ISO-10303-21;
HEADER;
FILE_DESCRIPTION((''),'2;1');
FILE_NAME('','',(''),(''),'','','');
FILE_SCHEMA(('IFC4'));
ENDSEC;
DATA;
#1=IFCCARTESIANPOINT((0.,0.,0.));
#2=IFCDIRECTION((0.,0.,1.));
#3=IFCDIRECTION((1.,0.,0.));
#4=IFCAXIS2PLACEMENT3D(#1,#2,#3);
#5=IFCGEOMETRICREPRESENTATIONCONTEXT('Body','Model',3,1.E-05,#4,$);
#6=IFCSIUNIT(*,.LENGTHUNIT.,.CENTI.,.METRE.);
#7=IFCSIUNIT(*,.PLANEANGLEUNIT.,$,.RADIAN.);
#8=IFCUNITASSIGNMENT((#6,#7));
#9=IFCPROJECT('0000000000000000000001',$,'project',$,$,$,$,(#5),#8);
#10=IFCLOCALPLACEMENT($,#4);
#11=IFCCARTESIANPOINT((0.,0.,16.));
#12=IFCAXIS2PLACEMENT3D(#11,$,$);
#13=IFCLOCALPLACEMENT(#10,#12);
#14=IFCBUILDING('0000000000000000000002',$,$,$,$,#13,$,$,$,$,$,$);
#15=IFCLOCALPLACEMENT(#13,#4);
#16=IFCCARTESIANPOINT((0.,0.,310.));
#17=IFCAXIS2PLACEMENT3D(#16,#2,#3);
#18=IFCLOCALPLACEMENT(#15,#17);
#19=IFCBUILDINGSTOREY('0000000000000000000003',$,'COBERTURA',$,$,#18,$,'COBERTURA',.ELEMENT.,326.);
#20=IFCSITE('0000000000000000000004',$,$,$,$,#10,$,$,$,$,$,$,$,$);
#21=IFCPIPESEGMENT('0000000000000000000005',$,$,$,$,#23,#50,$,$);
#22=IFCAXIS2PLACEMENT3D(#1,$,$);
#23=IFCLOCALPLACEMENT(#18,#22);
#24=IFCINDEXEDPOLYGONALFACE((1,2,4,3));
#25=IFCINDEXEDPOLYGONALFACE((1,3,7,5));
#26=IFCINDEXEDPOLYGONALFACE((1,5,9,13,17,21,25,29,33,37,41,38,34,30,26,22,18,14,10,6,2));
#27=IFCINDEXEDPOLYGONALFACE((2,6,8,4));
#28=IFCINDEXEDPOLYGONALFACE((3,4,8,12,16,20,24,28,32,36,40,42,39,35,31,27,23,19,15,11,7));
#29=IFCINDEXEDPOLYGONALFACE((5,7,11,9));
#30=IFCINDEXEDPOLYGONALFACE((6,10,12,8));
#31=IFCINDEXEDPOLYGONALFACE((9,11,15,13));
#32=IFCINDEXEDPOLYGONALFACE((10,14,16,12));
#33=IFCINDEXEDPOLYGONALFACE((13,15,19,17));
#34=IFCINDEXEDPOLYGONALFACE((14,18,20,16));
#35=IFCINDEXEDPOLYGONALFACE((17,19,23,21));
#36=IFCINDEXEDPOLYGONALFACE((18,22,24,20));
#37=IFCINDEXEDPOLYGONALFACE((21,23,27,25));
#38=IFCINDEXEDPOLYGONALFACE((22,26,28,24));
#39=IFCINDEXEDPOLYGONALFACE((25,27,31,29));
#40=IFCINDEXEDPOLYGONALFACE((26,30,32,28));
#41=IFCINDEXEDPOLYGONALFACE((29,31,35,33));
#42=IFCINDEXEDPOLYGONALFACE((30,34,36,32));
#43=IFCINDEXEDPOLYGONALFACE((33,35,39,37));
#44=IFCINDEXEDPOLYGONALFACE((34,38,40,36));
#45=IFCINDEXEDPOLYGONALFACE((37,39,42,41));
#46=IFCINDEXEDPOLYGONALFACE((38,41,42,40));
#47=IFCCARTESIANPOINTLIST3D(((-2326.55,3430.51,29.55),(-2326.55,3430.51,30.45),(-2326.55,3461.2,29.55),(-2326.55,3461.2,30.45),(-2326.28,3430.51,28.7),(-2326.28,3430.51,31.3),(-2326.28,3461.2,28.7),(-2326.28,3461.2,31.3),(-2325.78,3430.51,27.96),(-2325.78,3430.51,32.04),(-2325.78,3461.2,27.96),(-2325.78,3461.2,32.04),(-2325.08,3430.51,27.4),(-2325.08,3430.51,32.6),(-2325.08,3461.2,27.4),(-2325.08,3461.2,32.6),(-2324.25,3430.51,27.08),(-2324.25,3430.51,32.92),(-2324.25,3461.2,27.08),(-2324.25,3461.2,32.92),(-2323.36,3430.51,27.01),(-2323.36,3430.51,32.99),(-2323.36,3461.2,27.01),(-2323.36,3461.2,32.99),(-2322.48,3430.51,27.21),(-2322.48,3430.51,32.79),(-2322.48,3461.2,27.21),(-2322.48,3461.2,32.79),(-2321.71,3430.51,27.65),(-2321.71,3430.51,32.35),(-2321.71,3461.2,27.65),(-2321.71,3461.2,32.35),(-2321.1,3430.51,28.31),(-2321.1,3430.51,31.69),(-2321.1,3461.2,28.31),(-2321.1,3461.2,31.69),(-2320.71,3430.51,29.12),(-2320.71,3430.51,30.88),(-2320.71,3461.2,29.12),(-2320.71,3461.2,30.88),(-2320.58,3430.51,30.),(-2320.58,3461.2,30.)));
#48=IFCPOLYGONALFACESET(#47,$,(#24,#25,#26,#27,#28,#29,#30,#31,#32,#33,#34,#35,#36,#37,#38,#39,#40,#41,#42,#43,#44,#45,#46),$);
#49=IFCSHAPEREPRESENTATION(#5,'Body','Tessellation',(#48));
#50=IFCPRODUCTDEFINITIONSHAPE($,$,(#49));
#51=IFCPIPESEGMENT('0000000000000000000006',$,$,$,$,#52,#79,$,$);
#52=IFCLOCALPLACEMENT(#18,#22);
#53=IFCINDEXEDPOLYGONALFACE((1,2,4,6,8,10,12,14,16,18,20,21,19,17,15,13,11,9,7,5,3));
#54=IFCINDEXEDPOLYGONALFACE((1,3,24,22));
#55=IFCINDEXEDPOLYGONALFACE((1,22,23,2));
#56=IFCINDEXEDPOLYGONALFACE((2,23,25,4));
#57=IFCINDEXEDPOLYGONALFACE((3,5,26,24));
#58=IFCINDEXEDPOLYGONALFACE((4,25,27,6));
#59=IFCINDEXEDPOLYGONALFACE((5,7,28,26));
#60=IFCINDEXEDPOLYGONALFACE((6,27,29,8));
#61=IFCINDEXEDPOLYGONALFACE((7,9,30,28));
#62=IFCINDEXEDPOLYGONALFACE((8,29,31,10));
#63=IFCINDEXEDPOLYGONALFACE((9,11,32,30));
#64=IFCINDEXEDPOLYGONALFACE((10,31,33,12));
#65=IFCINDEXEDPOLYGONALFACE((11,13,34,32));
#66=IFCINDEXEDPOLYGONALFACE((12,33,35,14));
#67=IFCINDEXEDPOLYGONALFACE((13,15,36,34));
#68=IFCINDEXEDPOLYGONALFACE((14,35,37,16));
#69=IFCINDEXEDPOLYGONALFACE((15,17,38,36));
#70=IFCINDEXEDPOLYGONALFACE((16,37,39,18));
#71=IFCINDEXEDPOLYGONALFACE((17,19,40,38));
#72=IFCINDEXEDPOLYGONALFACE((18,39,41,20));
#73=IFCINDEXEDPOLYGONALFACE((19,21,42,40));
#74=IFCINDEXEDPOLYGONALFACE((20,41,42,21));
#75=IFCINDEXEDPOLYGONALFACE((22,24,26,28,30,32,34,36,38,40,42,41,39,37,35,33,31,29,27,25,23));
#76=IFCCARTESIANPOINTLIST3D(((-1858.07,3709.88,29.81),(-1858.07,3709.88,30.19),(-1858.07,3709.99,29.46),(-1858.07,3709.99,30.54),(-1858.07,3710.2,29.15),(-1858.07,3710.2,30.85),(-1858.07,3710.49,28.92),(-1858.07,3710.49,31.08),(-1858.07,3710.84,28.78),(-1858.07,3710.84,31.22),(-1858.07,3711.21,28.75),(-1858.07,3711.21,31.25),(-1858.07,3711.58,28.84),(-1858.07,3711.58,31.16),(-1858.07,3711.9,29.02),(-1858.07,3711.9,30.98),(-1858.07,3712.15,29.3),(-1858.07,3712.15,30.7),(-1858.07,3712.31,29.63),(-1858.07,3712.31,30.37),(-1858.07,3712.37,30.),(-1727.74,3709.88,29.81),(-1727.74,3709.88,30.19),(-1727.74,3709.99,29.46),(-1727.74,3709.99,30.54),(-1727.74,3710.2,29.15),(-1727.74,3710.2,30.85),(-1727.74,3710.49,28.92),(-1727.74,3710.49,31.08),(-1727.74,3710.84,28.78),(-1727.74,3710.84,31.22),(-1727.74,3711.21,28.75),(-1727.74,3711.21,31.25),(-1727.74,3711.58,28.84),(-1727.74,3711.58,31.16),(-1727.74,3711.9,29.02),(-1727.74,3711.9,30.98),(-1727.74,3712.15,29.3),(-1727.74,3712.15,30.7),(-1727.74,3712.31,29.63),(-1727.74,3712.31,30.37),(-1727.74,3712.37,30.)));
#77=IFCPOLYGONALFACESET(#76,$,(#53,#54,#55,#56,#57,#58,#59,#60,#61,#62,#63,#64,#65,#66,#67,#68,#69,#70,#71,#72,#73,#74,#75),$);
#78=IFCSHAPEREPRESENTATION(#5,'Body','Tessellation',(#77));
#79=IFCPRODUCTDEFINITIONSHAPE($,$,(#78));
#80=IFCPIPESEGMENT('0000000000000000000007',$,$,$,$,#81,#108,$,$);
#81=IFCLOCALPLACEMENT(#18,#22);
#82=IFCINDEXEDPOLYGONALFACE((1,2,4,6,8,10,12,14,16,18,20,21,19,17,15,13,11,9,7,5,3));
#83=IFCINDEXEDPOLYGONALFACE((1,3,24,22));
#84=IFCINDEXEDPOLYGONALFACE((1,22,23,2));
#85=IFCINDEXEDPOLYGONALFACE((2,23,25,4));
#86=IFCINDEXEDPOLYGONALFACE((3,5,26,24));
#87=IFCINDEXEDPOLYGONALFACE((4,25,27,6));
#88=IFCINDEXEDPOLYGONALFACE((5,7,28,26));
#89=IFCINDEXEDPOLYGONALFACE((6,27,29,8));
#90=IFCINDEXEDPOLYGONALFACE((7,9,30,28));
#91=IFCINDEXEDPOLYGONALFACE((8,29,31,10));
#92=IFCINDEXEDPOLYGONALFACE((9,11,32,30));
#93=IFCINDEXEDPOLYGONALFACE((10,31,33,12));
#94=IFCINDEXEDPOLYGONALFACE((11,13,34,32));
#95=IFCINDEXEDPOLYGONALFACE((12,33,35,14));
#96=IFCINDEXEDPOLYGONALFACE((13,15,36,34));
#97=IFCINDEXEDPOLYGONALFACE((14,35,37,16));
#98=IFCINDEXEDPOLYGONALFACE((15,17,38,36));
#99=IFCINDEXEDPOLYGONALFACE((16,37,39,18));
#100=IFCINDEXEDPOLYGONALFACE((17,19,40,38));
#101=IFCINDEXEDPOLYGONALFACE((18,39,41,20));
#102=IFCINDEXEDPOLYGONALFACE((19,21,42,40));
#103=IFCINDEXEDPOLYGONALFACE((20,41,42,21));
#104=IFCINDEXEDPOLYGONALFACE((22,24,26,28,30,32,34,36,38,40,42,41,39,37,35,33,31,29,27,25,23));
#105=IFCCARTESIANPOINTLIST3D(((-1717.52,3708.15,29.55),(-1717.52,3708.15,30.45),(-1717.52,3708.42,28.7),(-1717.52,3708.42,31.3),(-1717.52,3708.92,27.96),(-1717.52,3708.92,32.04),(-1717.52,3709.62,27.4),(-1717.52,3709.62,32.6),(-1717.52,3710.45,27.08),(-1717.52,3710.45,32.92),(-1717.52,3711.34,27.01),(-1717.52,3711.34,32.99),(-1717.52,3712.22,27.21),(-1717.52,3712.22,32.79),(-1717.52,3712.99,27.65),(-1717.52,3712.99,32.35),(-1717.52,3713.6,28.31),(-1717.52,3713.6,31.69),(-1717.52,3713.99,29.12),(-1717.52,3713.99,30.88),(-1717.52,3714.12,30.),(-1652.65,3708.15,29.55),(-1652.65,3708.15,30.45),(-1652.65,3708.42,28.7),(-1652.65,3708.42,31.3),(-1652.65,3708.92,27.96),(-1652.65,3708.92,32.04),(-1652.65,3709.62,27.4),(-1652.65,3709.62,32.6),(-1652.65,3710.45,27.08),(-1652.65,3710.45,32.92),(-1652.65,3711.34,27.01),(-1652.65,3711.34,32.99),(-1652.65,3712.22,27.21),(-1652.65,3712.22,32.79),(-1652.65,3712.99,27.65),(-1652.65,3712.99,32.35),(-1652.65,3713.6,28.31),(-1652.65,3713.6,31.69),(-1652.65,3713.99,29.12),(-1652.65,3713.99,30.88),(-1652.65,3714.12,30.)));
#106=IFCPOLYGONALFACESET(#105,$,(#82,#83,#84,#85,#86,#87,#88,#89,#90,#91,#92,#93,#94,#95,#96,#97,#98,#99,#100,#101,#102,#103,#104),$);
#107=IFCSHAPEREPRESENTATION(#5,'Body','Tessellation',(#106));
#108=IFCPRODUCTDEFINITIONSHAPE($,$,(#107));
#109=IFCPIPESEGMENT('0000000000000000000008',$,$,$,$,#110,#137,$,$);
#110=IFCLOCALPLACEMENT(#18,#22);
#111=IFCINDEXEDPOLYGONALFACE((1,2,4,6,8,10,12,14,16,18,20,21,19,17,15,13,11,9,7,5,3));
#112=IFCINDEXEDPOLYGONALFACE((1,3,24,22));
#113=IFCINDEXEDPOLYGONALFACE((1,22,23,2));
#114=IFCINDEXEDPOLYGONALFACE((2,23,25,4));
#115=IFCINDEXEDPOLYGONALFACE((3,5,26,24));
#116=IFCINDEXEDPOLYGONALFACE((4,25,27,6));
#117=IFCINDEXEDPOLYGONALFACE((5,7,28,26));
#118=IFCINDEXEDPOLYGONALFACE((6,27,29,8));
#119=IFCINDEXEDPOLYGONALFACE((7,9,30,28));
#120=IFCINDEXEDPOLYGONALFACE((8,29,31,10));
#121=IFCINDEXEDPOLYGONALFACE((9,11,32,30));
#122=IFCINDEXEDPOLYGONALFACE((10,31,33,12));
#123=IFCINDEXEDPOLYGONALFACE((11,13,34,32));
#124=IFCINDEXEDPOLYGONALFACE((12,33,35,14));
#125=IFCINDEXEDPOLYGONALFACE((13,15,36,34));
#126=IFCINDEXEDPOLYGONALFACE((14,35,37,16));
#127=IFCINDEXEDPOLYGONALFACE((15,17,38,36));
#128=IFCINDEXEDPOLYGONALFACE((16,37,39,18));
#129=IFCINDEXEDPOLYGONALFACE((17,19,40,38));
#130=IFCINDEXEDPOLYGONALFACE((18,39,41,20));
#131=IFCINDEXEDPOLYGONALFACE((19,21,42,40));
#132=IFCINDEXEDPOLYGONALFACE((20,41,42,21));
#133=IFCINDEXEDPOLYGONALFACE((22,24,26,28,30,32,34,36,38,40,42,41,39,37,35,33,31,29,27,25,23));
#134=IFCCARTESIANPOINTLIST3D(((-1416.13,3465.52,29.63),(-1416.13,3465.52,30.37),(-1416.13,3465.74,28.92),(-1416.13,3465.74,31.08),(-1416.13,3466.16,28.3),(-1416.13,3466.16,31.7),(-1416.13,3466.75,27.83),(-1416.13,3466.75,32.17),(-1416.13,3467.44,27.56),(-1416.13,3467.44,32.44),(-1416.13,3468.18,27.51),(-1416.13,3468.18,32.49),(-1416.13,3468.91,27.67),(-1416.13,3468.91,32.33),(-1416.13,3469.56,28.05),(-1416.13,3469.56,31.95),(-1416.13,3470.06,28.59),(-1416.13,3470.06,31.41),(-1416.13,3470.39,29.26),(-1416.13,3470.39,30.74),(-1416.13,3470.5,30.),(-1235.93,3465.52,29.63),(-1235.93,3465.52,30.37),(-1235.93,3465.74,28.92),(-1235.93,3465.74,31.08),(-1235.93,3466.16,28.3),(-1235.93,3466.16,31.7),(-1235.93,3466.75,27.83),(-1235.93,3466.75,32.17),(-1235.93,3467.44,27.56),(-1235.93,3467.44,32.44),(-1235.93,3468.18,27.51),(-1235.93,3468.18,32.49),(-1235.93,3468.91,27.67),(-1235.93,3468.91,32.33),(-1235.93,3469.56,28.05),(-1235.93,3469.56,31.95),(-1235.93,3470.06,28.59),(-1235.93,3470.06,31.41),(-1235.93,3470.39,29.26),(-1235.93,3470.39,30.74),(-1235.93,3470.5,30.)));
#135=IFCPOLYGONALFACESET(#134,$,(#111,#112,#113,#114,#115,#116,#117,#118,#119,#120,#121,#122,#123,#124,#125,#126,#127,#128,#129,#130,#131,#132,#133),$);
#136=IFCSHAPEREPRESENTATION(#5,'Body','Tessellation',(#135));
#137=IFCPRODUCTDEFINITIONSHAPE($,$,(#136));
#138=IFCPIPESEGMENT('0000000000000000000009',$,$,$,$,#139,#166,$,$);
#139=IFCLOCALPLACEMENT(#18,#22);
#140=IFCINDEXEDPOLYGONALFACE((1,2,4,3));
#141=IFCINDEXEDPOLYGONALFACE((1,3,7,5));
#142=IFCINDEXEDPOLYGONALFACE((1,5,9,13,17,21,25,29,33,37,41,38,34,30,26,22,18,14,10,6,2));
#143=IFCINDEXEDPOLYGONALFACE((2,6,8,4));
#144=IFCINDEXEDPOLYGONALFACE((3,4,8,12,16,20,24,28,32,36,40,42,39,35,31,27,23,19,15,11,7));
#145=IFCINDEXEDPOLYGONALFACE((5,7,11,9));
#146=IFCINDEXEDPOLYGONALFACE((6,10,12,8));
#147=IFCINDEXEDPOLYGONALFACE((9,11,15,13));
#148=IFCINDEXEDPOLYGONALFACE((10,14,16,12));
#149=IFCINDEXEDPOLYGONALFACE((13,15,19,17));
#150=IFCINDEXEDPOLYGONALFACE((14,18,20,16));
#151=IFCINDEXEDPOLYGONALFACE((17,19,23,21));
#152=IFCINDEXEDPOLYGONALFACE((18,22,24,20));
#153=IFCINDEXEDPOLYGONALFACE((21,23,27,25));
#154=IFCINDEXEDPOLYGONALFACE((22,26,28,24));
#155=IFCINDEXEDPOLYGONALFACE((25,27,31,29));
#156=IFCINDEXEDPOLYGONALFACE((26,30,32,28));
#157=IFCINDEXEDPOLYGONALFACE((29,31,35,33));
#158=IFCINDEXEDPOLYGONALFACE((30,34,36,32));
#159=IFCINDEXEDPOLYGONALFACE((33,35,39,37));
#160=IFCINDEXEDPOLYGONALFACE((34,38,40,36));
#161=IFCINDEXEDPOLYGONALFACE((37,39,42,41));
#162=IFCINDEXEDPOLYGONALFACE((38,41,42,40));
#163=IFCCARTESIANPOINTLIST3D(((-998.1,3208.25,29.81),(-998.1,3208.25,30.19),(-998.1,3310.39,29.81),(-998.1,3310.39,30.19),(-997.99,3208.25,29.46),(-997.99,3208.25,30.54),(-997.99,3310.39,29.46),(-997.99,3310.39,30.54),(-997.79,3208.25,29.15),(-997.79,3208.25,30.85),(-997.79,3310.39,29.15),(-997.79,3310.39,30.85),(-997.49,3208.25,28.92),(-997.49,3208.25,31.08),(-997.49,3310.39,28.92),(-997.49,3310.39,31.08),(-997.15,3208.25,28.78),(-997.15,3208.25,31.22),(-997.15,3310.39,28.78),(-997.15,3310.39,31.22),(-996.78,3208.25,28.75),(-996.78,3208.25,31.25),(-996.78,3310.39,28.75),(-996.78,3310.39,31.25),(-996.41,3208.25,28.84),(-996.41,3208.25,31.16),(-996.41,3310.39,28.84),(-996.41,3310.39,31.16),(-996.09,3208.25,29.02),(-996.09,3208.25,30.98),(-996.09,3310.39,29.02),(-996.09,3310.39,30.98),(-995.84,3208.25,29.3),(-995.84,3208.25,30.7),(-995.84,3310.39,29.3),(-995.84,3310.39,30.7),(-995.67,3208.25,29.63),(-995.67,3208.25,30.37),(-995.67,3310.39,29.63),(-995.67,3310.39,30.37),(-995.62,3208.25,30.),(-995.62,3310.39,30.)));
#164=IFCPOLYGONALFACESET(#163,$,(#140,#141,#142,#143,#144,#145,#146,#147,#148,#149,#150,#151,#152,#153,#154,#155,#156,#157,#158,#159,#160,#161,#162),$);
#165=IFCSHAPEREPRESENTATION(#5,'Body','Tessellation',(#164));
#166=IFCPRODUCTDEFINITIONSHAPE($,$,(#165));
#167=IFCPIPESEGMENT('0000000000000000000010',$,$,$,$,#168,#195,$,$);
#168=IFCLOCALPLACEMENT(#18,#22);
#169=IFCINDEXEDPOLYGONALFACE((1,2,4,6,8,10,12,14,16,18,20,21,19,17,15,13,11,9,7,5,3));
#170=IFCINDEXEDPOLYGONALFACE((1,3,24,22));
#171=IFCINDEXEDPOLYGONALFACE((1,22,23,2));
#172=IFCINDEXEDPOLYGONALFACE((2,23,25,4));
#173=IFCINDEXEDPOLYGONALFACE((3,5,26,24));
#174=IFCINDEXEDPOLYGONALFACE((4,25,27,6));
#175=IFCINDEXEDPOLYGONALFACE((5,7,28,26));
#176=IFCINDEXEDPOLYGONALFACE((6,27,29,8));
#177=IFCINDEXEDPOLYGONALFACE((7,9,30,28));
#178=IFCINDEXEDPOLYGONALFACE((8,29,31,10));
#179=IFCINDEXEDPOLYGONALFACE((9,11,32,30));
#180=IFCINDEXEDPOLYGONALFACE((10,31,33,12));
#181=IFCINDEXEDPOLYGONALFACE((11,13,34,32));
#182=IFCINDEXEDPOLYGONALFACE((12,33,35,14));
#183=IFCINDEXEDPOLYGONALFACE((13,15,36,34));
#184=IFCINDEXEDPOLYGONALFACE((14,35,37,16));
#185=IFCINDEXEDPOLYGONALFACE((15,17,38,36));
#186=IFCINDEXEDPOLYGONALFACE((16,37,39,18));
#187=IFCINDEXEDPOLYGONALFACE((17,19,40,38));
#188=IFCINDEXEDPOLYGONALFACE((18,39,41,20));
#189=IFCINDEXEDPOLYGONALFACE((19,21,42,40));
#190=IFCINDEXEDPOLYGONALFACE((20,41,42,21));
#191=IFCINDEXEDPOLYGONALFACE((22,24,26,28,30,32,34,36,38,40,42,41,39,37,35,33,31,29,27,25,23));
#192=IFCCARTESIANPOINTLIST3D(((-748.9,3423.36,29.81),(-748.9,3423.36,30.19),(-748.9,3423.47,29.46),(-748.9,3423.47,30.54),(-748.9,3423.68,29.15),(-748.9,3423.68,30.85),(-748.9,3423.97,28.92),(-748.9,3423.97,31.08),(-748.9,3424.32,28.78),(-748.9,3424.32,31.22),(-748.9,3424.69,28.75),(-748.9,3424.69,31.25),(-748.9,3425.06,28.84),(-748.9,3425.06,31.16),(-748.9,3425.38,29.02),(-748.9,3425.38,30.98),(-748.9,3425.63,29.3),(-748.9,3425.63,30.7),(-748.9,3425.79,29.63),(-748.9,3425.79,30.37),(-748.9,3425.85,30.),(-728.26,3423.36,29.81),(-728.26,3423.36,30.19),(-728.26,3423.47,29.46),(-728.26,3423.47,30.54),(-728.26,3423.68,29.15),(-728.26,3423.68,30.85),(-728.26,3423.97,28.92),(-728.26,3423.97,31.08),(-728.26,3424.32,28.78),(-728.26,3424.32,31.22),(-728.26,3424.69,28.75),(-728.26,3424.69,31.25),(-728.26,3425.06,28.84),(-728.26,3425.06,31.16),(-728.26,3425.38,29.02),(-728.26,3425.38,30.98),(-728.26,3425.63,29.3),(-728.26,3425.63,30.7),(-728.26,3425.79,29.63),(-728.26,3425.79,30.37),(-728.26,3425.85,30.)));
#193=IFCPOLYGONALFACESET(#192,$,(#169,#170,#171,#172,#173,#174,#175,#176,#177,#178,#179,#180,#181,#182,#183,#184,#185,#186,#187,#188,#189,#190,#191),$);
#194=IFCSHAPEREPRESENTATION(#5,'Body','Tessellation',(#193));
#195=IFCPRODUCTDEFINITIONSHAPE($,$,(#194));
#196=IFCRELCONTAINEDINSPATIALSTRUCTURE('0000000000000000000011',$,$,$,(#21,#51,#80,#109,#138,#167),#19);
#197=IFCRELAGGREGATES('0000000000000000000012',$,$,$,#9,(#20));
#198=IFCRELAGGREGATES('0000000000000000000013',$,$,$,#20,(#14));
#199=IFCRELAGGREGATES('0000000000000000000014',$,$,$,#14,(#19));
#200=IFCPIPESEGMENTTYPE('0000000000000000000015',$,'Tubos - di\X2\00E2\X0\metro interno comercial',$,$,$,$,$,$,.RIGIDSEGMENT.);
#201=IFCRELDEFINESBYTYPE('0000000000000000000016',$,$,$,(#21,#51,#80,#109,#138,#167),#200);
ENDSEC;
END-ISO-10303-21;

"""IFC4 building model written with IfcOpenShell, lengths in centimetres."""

from ifc_helpers import new_model, si_unit, frame, origin_with_axes, origin_2d_with_axis, place, context, project, spatial, circle, extrude, type_object, element, save


model = new_model("IFC4")

# Units and contexts
model_context = context("Model", 3, precision=1e-05, world=origin_with_axes(), identifier="Body")
ifc_project = project(units=[si_unit("LENGTHUNIT", "METRE", prefix="CENTI"), si_unit("PLANEANGLEUNIT", "RADIAN")], contexts=[model_context])

# Site, building, storey
site_placement = place(None, origin_with_axes())
site = spatial("IfcSite", under=ifc_project, at=site_placement)
building_placement = place(site_placement, frame((0.0, 0.0, 16.0)))
building = spatial("IfcBuilding", under=site, at=building_placement)
placement = place(building_placement, origin_with_axes())
storey_placement = place(placement, frame((0.0, 0.0, 310.0), z_axis=(0.0, 0.0, 1.0), x_axis=(1.0, 0.0, 0.0)))
storey = spatial("IfcBuildingStorey", under=building, at=storey_placement, Name="COBERTURA", LongName="COBERTURA", CompositionType="ELEMENT", Elevation=326.0)

# Pipe segments
pipe_segment_type = type_object("IfcPipeSegmentType", Name="Tubos - diâmetro interno comercial", PredefinedType="RIGIDSEGMENT")
pipe_segment_1_placement = place(storey_placement, frame((-2323.58, 3445.85, 33.0), z_axis=(0.0, 0.0, 1.0), x_axis=(1.0, 0.0, 0.0)))
element("IfcPipeSegment", 1, at=pipe_segment_1_placement, inside=storey, type_object=pipe_segment_type, context=model_context, shape_type="SolidModel", body=[
    extrude(circle(Radius=3.0, at=origin_2d_with_axis()), frame((0.0, -15.34, -3.0), z_axis=(0.0, 1.0, 0.0), x_axis=(1.0, 0.0, 0.0)), (0.0, 0.0, 1.0), 30.69),
])
pipe_segment_2_placement = place(storey_placement, frame((-1792.91, 3711.12, 31.25), z_axis=(0.0, 0.0, 1.0), x_axis=(1.0, 0.0, 0.0)))
element("IfcPipeSegment", 2, at=pipe_segment_2_placement, inside=storey, type_object=pipe_segment_type, context=model_context, shape_type="SolidModel", body=[
    extrude(circle(Radius=1.25, at=origin_2d_with_axis()), frame((65.16, 0.0, -1.25), z_axis=(-1.0, 0.0, 0.0), x_axis=(0.0, 1.0, 0.0)), (0.0, 0.0, 1.0), 130.33),
])
pipe_segment_3_placement = place(storey_placement, frame((-1685.08, 3711.12, 33.0), z_axis=(0.0, 0.0, 1.0), x_axis=(1.0, 0.0, 0.0)))
element("IfcPipeSegment", 3, at=pipe_segment_3_placement, inside=storey, type_object=pipe_segment_type, context=model_context, shape_type="SolidModel", body=[
    extrude(circle(Radius=3.0, at=origin_2d_with_axis()), frame((32.44, 0.0, -3.0), z_axis=(-1.0, 0.0, 0.0), x_axis=(0.0, 1.0, 0.0)), (0.0, 0.0, 1.0), 64.87),
])
pipe_segment_4_placement = place(storey_placement, frame((-1326.03, 3468.0, 32.5), z_axis=(0.0, 0.0, 1.0), x_axis=(1.0, 0.0, 0.0)))
element("IfcPipeSegment", 4, at=pipe_segment_4_placement, inside=storey, type_object=pipe_segment_type, context=model_context, shape_type="SolidModel", body=[
    extrude(circle(Radius=2.5, at=origin_2d_with_axis()), frame((-90.1, 0.0, -2.5), z_axis=(1.0, 0.0, 0.0), x_axis=(0.0, 1.0, 0.0)), (0.0, 0.0, 1.0), 180.2),
])
pipe_segment_5_placement = place(storey_placement, frame((-996.87, 3259.32, 31.25), z_axis=(0.0, 0.0, 1.0), x_axis=(1.0, 0.0, 0.0)))
element("IfcPipeSegment", 5, at=pipe_segment_5_placement, inside=storey, type_object=pipe_segment_type, context=model_context, shape_type="SolidModel", body=[
    extrude(circle(Radius=1.25, at=origin_2d_with_axis()), frame((0.0, 51.07, -1.25), z_axis=(0.0, -1.0, 0.0), x_axis=(1.0, 0.0, 0.0)), (0.0, 0.0, 1.0), 102.14),
])
pipe_segment_6_placement = place(storey_placement, frame((-738.58, 3424.6, 31.25), z_axis=(0.0, 0.0, 1.0), x_axis=(1.0, 0.0, 0.0)))
element("IfcPipeSegment", 6, at=pipe_segment_6_placement, inside=storey, type_object=pipe_segment_type, context=model_context, shape_type="SolidModel", body=[
    extrude(circle(Radius=1.25, at=origin_2d_with_axis()), frame((-10.32, 0.0, -1.25), z_axis=(1.0, 0.0, 0.0), x_axis=(0.0, 1.0, 0.0)), (0.0, 0.0, 1.0), 20.64),
])

save(model, "model.ifc")
